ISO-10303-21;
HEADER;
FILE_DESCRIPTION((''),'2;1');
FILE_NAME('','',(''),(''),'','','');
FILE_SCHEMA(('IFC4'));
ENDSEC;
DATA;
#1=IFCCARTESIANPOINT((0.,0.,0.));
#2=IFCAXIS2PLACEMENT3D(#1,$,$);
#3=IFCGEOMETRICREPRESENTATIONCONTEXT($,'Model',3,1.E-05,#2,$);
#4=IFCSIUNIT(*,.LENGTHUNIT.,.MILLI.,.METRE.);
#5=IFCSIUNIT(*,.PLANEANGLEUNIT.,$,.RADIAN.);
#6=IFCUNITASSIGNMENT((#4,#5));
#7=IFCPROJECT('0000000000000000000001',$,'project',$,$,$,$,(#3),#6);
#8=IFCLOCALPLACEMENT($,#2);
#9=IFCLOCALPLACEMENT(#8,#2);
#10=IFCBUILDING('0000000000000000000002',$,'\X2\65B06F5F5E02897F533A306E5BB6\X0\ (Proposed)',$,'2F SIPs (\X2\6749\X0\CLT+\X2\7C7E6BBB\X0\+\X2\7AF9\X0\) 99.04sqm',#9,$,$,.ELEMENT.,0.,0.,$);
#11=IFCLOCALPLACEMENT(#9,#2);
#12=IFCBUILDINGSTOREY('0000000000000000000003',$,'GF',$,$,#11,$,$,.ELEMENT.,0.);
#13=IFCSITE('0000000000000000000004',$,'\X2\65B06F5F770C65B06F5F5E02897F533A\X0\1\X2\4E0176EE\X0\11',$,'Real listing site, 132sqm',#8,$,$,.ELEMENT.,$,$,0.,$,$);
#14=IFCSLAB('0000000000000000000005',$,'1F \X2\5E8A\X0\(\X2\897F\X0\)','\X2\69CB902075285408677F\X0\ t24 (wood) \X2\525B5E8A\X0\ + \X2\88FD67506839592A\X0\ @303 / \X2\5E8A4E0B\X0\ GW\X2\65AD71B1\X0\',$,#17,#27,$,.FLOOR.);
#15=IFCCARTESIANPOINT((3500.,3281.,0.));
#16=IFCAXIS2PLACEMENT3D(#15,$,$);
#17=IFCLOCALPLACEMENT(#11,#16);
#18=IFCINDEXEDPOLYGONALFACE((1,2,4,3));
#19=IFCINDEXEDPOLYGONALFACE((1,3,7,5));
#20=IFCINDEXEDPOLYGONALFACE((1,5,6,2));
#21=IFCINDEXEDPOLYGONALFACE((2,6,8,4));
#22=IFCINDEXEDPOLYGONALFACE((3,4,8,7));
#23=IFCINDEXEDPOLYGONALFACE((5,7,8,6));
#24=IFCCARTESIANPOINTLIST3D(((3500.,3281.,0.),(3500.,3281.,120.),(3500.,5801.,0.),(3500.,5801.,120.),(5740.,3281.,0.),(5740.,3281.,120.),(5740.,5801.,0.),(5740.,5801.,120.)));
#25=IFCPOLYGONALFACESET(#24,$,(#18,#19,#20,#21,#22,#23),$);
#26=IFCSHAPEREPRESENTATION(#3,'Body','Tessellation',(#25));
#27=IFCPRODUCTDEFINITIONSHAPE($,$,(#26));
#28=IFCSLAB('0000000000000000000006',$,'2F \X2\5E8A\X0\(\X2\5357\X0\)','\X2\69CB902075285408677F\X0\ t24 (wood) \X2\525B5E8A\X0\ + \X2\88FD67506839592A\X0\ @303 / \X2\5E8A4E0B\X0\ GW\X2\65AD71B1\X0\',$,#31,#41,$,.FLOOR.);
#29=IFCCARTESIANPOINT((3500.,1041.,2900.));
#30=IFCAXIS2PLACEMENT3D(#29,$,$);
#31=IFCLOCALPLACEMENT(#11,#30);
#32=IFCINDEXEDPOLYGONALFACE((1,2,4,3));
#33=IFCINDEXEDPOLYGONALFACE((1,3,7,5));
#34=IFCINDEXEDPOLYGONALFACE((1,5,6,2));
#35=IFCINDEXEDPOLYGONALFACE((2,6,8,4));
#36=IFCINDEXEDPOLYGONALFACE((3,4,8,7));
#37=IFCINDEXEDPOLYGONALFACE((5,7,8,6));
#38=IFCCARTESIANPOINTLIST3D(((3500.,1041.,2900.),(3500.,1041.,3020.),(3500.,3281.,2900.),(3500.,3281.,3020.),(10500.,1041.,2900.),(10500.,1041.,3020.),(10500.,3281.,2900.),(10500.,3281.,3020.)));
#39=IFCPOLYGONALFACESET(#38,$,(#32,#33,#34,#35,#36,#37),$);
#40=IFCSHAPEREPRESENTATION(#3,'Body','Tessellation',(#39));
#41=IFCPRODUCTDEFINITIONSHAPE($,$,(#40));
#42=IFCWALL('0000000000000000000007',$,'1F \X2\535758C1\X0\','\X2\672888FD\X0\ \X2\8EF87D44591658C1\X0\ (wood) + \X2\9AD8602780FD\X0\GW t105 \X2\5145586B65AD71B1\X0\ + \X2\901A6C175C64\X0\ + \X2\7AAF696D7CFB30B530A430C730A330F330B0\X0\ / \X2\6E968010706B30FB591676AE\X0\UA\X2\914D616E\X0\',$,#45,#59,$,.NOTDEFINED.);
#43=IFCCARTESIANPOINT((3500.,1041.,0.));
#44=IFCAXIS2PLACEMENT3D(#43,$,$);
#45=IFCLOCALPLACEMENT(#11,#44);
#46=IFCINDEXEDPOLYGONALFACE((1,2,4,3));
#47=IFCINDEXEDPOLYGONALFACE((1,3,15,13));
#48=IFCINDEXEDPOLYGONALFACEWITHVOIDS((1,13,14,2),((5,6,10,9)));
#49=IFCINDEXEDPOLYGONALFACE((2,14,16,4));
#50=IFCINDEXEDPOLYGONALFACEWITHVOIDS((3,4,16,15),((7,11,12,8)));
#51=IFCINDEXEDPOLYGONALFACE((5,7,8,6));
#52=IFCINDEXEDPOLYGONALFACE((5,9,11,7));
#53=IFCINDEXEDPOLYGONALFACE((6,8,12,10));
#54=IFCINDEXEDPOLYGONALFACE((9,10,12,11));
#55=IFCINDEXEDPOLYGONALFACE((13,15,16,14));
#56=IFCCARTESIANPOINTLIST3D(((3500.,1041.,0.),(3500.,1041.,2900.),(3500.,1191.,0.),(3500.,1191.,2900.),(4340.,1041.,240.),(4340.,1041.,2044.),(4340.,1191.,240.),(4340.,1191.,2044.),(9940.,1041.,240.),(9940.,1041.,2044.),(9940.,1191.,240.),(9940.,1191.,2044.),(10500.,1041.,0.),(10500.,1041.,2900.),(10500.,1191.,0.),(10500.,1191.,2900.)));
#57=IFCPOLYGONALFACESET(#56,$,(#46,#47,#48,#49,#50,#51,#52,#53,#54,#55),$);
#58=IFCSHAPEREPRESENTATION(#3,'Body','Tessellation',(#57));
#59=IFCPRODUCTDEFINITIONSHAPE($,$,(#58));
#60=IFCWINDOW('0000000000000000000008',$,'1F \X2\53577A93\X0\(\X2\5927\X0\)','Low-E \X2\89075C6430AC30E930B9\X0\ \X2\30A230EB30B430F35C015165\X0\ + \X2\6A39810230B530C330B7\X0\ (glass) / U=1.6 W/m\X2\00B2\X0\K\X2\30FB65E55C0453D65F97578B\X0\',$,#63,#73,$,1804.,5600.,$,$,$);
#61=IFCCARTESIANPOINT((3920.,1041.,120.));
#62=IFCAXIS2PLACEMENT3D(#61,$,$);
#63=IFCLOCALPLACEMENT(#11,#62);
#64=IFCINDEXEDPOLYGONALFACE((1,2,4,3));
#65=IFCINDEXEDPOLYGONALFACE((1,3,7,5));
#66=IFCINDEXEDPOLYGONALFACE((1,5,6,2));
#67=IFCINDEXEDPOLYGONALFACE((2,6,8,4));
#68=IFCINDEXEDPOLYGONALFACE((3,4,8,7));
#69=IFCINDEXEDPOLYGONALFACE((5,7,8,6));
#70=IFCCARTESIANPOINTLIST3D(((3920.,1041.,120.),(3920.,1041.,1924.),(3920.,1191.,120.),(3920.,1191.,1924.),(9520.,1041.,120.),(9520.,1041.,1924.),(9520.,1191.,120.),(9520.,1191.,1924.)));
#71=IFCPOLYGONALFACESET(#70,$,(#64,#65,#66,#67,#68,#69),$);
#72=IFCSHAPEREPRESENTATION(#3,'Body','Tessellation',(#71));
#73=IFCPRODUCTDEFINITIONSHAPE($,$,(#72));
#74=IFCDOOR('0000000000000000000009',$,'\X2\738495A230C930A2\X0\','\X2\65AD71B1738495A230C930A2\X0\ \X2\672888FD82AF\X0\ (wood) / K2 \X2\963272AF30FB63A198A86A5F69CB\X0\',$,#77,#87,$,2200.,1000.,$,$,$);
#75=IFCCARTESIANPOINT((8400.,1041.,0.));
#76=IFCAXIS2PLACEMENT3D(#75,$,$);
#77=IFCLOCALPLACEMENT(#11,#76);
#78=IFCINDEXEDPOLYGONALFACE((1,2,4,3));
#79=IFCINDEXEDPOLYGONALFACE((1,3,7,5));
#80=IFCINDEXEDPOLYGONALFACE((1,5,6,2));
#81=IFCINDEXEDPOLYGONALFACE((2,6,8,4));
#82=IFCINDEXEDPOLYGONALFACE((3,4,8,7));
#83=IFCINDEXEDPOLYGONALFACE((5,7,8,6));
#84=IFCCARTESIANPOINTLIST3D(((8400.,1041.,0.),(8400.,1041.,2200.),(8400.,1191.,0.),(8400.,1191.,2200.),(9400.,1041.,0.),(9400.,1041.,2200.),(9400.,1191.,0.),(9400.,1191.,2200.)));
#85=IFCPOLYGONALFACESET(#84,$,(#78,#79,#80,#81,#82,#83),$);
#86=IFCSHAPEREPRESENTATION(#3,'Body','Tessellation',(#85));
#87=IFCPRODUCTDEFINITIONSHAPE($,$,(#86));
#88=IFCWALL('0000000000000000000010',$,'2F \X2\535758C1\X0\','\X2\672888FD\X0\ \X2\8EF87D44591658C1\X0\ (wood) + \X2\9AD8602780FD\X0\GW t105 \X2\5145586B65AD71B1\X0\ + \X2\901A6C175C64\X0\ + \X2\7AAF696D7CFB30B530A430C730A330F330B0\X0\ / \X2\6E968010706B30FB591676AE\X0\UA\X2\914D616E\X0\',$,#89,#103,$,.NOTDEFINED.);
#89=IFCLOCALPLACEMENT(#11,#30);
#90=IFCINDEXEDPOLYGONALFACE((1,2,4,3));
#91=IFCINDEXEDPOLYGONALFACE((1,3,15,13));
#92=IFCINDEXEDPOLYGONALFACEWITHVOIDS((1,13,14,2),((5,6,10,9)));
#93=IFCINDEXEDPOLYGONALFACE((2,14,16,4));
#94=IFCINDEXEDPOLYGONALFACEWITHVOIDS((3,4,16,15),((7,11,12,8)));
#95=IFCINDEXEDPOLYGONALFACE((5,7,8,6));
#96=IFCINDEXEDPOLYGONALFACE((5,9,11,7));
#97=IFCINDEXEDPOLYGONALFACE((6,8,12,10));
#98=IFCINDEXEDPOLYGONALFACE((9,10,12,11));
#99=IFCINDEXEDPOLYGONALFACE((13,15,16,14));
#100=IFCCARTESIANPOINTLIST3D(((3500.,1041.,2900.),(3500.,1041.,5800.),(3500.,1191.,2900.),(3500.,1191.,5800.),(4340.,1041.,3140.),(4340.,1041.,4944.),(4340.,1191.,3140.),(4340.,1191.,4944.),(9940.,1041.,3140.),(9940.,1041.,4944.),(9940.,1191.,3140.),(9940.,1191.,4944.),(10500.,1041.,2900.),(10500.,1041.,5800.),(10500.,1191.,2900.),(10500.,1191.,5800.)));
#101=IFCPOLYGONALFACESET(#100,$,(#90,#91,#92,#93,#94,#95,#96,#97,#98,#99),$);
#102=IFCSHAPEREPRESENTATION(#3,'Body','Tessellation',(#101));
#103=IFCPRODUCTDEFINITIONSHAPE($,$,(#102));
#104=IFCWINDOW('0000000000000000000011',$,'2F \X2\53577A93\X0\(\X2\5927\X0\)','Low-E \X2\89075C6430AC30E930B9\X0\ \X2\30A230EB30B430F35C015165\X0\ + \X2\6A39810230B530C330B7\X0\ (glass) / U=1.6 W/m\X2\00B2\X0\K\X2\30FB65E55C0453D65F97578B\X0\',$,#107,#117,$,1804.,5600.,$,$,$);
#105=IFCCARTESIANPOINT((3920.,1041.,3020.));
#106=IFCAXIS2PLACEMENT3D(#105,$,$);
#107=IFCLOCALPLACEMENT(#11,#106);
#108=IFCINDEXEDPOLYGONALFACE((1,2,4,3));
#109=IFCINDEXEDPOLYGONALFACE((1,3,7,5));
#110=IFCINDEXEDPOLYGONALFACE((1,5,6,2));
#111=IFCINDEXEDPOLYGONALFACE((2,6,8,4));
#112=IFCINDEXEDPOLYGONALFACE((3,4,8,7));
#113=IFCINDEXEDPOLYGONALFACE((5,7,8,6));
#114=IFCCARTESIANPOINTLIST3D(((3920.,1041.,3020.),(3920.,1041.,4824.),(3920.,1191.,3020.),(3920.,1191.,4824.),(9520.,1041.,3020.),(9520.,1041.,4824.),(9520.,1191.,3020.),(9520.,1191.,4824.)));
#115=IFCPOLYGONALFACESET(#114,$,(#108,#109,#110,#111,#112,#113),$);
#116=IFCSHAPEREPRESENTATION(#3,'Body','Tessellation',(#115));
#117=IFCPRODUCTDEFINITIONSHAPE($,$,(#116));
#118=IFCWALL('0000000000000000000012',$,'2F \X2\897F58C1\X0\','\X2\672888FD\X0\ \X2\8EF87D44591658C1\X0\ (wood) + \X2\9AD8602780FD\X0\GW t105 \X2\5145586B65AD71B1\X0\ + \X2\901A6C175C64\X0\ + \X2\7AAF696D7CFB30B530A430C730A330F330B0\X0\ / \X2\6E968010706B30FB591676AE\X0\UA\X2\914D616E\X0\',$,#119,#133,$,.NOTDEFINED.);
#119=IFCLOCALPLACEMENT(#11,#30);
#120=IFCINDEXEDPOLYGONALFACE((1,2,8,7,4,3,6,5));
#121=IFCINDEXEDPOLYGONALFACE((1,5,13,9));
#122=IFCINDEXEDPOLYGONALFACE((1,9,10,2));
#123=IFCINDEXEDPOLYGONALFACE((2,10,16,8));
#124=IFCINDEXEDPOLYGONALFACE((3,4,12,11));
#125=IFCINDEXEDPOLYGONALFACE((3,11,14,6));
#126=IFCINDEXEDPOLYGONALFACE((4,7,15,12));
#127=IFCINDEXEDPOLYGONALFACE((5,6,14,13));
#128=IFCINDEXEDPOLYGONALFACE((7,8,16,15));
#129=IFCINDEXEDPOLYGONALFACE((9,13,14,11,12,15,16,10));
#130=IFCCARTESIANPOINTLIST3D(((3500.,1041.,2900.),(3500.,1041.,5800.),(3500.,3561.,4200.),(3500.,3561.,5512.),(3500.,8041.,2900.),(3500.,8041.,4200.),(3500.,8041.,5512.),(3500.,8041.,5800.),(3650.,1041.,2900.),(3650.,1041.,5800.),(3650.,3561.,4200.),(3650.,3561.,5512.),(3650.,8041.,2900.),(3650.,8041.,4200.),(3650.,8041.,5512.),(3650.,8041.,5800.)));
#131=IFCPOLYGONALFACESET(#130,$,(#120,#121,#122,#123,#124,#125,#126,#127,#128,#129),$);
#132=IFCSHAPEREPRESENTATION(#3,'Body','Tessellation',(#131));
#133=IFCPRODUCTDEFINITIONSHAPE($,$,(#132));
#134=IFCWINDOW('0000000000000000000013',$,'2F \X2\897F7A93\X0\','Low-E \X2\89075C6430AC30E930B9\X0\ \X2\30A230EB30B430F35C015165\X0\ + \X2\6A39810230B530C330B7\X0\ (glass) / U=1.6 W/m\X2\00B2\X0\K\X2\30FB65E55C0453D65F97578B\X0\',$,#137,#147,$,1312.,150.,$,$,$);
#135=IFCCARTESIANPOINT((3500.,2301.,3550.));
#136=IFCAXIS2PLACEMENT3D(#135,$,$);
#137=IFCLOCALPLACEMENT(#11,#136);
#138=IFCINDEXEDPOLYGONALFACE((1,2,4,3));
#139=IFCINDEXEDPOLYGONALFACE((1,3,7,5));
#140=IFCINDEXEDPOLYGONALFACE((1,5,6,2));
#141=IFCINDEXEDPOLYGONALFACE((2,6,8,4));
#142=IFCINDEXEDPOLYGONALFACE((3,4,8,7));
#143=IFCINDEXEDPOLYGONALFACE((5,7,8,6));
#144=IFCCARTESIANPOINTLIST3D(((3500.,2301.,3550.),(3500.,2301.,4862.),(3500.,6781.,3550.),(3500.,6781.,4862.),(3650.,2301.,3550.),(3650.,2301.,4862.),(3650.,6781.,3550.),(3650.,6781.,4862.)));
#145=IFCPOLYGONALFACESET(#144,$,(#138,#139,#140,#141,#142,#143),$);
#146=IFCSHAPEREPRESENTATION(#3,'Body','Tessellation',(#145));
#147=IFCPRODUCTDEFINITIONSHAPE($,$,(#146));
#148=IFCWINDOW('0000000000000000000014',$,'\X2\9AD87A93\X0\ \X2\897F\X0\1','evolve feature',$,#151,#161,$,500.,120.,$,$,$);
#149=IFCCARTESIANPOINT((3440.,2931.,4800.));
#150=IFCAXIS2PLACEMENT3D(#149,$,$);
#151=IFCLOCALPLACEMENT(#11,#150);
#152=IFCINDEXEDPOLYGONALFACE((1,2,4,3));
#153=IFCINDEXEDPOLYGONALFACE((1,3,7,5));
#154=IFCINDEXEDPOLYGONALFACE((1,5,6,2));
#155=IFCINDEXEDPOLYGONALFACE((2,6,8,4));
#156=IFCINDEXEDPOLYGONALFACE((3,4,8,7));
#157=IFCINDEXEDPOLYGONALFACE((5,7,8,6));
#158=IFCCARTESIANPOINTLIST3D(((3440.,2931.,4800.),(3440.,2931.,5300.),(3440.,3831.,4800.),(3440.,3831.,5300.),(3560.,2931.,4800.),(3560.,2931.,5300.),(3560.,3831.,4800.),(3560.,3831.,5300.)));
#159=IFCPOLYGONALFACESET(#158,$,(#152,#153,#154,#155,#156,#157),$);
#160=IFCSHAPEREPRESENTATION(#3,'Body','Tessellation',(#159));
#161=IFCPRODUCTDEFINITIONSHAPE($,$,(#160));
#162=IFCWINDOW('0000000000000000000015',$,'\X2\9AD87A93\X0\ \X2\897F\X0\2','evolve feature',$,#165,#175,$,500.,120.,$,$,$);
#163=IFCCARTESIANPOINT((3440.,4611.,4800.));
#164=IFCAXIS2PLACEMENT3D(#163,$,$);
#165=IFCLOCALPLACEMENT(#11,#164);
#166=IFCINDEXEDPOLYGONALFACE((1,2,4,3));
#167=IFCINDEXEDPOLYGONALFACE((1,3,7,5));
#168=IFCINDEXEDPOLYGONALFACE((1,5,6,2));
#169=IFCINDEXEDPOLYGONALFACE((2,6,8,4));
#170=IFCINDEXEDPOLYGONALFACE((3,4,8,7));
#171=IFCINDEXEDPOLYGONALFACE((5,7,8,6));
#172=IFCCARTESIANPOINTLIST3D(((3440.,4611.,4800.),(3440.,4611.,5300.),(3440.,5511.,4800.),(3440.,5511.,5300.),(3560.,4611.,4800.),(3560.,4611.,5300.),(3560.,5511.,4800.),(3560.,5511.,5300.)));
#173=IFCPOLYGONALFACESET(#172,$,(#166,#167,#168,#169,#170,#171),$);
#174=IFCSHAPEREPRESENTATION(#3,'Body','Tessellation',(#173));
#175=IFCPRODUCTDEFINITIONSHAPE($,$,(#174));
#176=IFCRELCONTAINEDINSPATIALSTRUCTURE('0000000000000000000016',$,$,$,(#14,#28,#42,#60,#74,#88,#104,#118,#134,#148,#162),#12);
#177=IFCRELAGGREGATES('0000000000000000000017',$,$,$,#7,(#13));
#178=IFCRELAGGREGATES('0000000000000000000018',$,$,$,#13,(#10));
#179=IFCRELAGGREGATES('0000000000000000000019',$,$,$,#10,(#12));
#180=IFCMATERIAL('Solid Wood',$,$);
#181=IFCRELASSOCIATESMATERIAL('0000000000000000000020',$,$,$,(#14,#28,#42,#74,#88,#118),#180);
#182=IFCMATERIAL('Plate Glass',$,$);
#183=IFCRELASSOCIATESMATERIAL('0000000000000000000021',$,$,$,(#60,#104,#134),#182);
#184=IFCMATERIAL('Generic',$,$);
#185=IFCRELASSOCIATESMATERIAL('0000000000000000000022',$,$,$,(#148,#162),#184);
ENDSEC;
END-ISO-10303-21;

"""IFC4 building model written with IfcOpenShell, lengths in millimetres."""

from ifc_helpers import new_model, si_unit, frame, frame_2d, origin, place, context, project, spatial, rectangle, extrude, material, element, fill, save


model = new_model("IFC4")

# Units and contexts
model_context = context("Model", 3, precision=1e-05, world=origin())
ifc_project = project(units=[si_unit("LENGTHUNIT", "METRE", prefix="MILLI"), si_unit("PLANEANGLEUNIT", "RADIAN")], contexts=[model_context])

# Site, building, storey
site_placement = place(None, origin())
site = spatial("IfcSite", under=ifc_project, at=site_placement, Name="新潟県新潟市西区1丁目11", ObjectType="Real listing site, 132sqm", CompositionType="ELEMENT", RefElevation=0.0)
building_placement = place(site_placement, origin())
building = spatial("IfcBuilding", under=site, at=building_placement, Name="新潟市西区の家 (Proposed)", ObjectType="2F SIPs (杉CLT+籾殻+竹) 99.04sqm", CompositionType="ELEMENT", ElevationOfRefHeight=0.0, ElevationOfTerrain=0.0)
storey_placement = place(building_placement, origin())
storey = spatial("IfcBuildingStorey", under=building, at=storey_placement, Name="GF", CompositionType="ELEMENT", Elevation=0.0)

# Slabs
ifc_material_1 = material(Name="Solid Wood")
slab_1_placement = place(storey_placement, frame((3500.0, 3281.0, 0.0)))
element("IfcSlab", 1, at=slab_1_placement, inside=storey, material=ifc_material_1, Name="1F 床(西)", Description="構造用合板 t24 (wood) 剛床 + 製材根太 @303 / 床下 GW断熱", PredefinedType="FLOOR", context=model_context, shape_type="SweptSolid", body=[
    extrude(rectangle(XDim=2240.0, YDim=2520.0, at=frame_2d((1120.0, 1260.0))), frame((3500.0, 3281.0, 0.0)), (0.0, 0.0, 1.0), 120.0),
])
slab_2_placement = place(storey_placement, frame((3500.0, 1041.0, 2900.0)))
element("IfcSlab", 2, at=slab_2_placement, inside=storey, material=ifc_material_1, Name="2F 床(南)", Description="構造用合板 t24 (wood) 剛床 + 製材根太 @303 / 床下 GW断熱", PredefinedType="FLOOR", context=model_context, shape_type="SweptSolid", body=[
    extrude(rectangle(XDim=7000.0, YDim=2240.0, at=frame_2d((3500.0, 1120.0))), frame((3500.0, 1041.0, 2900.0)), (0.0, 0.0, 1.0), 120.0),
])
ifc_material_2 = material(Name="Generic")

# Wall, openings, window, door
wall_1_placement = place(storey_placement, frame((3500.0, 1041.0, 0.0)))
wall_1 = element("IfcWall", 3, at=wall_1_placement, inside=storey, material=ifc_material_1, Name="1F 南壁", Description="木製 軸組外壁 (wood) + 高性能GW t105 充填断熱 + 通気層 + 窯業系サイディング / 準耐火・外皮UA配慮", PredefinedType="NOTDEFINED", context=model_context, shape_type="SweptSolid", body=[
    extrude(rectangle(XDim=7000.0, YDim=150.0, at=frame_2d((3500.0, 75.0))), frame((3500.0, 1041.0, 0.0)), (0.0, 0.0, 1.0), 2900.0),
])
opening_1_placement = place(storey_placement, frame((3920.0, 1041.0, 120.0)))
opening_1 = element("IfcOpeningElement", 4, at=opening_1_placement, cuts=wall_1, PredefinedType="NOTDEFINED", context=model_context, shape_type="SweptSolid", body=[
    extrude(rectangle(XDim=5600.0, YDim=150.0, at=frame_2d((2800.0, 75.0))), frame((3920.0, 1041.0, 120.0)), (0.0, 0.0, 1.0), 1804.0),
])
opening_2_placement = place(storey_placement, frame((8400.0, 1041.0, 0.0)))
opening_2 = element("IfcOpeningElement", 5, at=opening_2_placement, cuts=wall_1, PredefinedType="NOTDEFINED", context=model_context, shape_type="SweptSolid", body=[
    extrude(rectangle(XDim=1000.0, YDim=150.0, at=frame_2d((500.0, 75.0))), frame((8400.0, 1041.0, 0.0)), (0.0, 0.0, 1.0), 2200.0),
])
ifc_material_3 = material(Name="Plate Glass")
window_1_placement = place(storey_placement, frame((3920.0, 1041.0, 120.0)))
window_1 = element("IfcWindow", 6, at=window_1_placement, inside=storey, material=ifc_material_3, Name="1F 南窓(大)", Description="Low-E 複層ガラス アルゴン封入 + 樹脂サッシ (glass) / U=1.6 W/m²K・日射取得型", OverallHeight=1804.0, OverallWidth=5600.0, context=model_context, shape_type="SweptSolid", body=[
    extrude(rectangle(XDim=5600.0, YDim=150.0, at=frame_2d((2800.0, 75.0))), frame((3920.0, 1041.0, 120.0)), (0.0, 0.0, 1.0), 1804.0),
])
fill(opening_1, window_1)
door_placement = place(storey_placement, frame((8400.0, 1041.0, 0.0)))
door = element("IfcDoor", 7, at=door_placement, inside=storey, material=ifc_material_1, Name="玄関ドア", Description="断熱玄関ドア 木製芯 (wood) / K2 防犯・採風機構", OverallHeight=2200.0, OverallWidth=1000.0, context=model_context, shape_type="SweptSolid", body=[
    extrude(rectangle(XDim=1000.0, YDim=150.0, at=frame_2d((500.0, 75.0))), frame((8400.0, 1041.0, 0.0)), (0.0, 0.0, 1.0), 2200.0),
])
fill(opening_2, door)

# Wall, opening, window
wall_2_placement = place(storey_placement, frame((3500.0, 1041.0, 2900.0)))
wall_2 = element("IfcWall", 8, at=wall_2_placement, inside=storey, material=ifc_material_1, Name="2F 南壁", Description="木製 軸組外壁 (wood) + 高性能GW t105 充填断熱 + 通気層 + 窯業系サイディング / 準耐火・外皮UA配慮", PredefinedType="NOTDEFINED", context=model_context, shape_type="SweptSolid", body=[
    extrude(rectangle(XDim=7000.0, YDim=150.0, at=frame_2d((3500.0, 75.0))), frame((3500.0, 1041.0, 2900.0)), (0.0, 0.0, 1.0), 2900.0),
])
opening_3_placement = place(storey_placement, frame((3920.0, 1041.0, 3020.0)))
opening_3 = element("IfcOpeningElement", 9, at=opening_3_placement, cuts=wall_2, PredefinedType="NOTDEFINED", context=model_context, shape_type="SweptSolid", body=[
    extrude(rectangle(XDim=5600.0, YDim=150.0, at=frame_2d((2800.0, 75.0))), frame((3920.0, 1041.0, 3020.0)), (0.0, 0.0, 1.0), 1804.0),
])
window_2_placement = place(storey_placement, frame((3920.0, 1041.0, 3020.0)))
window_2 = element("IfcWindow", 10, at=window_2_placement, inside=storey, material=ifc_material_3, Name="2F 南窓(大)", Description="Low-E 複層ガラス アルゴン封入 + 樹脂サッシ (glass) / U=1.6 W/m²K・日射取得型", OverallHeight=1804.0, OverallWidth=5600.0, context=model_context, shape_type="SweptSolid", body=[
    extrude(rectangle(XDim=5600.0, YDim=150.0, at=frame_2d((2800.0, 75.0))), frame((3920.0, 1041.0, 3020.0)), (0.0, 0.0, 1.0), 1804.0),
])
fill(opening_3, window_2)

# Wall, openings, windows
wall_3_placement = place(storey_placement, frame((3500.0, 1041.0, 2900.0)))
wall_3 = element("IfcWall", 11, at=wall_3_placement, inside=storey, material=ifc_material_1, Name="2F 西壁", Description="木製 軸組外壁 (wood) + 高性能GW t105 充填断熱 + 通気層 + 窯業系サイディング / 準耐火・外皮UA配慮", PredefinedType="NOTDEFINED", context=model_context, shape_type="SweptSolid", body=[
    extrude(rectangle(XDim=150.0, YDim=7000.0, at=frame_2d((75.0, 3500.0))), frame((3500.0, 1041.0, 2900.0)), (0.0, 0.0, 1.0), 2900.0),
])
opening_4_placement = place(storey_placement, frame((3500.0, 2301.0, 3550.0)))
opening_4 = element("IfcOpeningElement", 12, at=opening_4_placement, cuts=wall_3, PredefinedType="NOTDEFINED", context=model_context, shape_type="SweptSolid", body=[
    extrude(rectangle(XDim=150.0, YDim=4480.0, at=frame_2d((75.0, 2240.0))), frame((3500.0, 2301.0, 3550.0)), (0.0, 0.0, 1.0), 1312.0),
])
opening_5_placement = place(storey_placement, frame((3440.0, 2931.0, 4800.0)))
opening_5 = element("IfcOpeningElement", 13, at=opening_5_placement, cuts=wall_3, PredefinedType="NOTDEFINED", context=model_context, shape_type="SweptSolid", body=[
    extrude(rectangle(XDim=120.0, YDim=900.0, at=frame_2d((60.0, 450.0))), frame((3440.0, 2931.0, 4800.0)), (0.0, 0.0, 1.0), 500.0),
])
opening_6_placement = place(storey_placement, frame((3440.0, 4611.0, 4800.0)))
opening_6 = element("IfcOpeningElement", 14, at=opening_6_placement, cuts=wall_3, PredefinedType="NOTDEFINED", context=model_context, shape_type="SweptSolid", body=[
    extrude(rectangle(XDim=120.0, YDim=900.0, at=frame_2d((60.0, 450.0))), frame((3440.0, 4611.0, 4800.0)), (0.0, 0.0, 1.0), 500.0),
])
window_3_placement = place(storey_placement, frame((3500.0, 2301.0, 3550.0)))
window_3 = element("IfcWindow", 15, at=window_3_placement, inside=storey, material=ifc_material_3, Name="2F 西窓", Description="Low-E 複層ガラス アルゴン封入 + 樹脂サッシ (glass) / U=1.6 W/m²K・日射取得型", OverallHeight=1312.0, OverallWidth=150.0, context=model_context, shape_type="SweptSolid", body=[
    extrude(rectangle(XDim=150.0, YDim=4480.0, at=frame_2d((75.0, 2240.0))), frame((3500.0, 2301.0, 3550.0)), (0.0, 0.0, 1.0), 1312.0),
])
fill(opening_4, window_3)
window_4_placement = place(storey_placement, frame((3440.0, 2931.0, 4800.0)))
window_4 = element("IfcWindow", 16, at=window_4_placement, inside=storey, material=ifc_material_2, Name="高窓 西1", Description="evolve feature", OverallHeight=500.0, OverallWidth=120.0, context=model_context, shape_type="SweptSolid", body=[
    extrude(rectangle(XDim=120.0, YDim=900.0, at=frame_2d((60.0, 450.0))), frame((3440.0, 2931.0, 4800.0)), (0.0, 0.0, 1.0), 500.0),
])
fill(opening_5, window_4)
window_5_placement = place(storey_placement, frame((3440.0, 4611.0, 4800.0)))
window_5 = element("IfcWindow", 17, at=window_5_placement, inside=storey, material=ifc_material_2, Name="高窓 西2", Description="evolve feature", OverallHeight=500.0, OverallWidth=120.0, context=model_context, shape_type="SweptSolid", body=[
    extrude(rectangle(XDim=120.0, YDim=900.0, at=frame_2d((60.0, 450.0))), frame((3440.0, 4611.0, 4800.0)), (0.0, 0.0, 1.0), 500.0),
])
fill(opening_6, window_5)

save(model, "model.ifc")
